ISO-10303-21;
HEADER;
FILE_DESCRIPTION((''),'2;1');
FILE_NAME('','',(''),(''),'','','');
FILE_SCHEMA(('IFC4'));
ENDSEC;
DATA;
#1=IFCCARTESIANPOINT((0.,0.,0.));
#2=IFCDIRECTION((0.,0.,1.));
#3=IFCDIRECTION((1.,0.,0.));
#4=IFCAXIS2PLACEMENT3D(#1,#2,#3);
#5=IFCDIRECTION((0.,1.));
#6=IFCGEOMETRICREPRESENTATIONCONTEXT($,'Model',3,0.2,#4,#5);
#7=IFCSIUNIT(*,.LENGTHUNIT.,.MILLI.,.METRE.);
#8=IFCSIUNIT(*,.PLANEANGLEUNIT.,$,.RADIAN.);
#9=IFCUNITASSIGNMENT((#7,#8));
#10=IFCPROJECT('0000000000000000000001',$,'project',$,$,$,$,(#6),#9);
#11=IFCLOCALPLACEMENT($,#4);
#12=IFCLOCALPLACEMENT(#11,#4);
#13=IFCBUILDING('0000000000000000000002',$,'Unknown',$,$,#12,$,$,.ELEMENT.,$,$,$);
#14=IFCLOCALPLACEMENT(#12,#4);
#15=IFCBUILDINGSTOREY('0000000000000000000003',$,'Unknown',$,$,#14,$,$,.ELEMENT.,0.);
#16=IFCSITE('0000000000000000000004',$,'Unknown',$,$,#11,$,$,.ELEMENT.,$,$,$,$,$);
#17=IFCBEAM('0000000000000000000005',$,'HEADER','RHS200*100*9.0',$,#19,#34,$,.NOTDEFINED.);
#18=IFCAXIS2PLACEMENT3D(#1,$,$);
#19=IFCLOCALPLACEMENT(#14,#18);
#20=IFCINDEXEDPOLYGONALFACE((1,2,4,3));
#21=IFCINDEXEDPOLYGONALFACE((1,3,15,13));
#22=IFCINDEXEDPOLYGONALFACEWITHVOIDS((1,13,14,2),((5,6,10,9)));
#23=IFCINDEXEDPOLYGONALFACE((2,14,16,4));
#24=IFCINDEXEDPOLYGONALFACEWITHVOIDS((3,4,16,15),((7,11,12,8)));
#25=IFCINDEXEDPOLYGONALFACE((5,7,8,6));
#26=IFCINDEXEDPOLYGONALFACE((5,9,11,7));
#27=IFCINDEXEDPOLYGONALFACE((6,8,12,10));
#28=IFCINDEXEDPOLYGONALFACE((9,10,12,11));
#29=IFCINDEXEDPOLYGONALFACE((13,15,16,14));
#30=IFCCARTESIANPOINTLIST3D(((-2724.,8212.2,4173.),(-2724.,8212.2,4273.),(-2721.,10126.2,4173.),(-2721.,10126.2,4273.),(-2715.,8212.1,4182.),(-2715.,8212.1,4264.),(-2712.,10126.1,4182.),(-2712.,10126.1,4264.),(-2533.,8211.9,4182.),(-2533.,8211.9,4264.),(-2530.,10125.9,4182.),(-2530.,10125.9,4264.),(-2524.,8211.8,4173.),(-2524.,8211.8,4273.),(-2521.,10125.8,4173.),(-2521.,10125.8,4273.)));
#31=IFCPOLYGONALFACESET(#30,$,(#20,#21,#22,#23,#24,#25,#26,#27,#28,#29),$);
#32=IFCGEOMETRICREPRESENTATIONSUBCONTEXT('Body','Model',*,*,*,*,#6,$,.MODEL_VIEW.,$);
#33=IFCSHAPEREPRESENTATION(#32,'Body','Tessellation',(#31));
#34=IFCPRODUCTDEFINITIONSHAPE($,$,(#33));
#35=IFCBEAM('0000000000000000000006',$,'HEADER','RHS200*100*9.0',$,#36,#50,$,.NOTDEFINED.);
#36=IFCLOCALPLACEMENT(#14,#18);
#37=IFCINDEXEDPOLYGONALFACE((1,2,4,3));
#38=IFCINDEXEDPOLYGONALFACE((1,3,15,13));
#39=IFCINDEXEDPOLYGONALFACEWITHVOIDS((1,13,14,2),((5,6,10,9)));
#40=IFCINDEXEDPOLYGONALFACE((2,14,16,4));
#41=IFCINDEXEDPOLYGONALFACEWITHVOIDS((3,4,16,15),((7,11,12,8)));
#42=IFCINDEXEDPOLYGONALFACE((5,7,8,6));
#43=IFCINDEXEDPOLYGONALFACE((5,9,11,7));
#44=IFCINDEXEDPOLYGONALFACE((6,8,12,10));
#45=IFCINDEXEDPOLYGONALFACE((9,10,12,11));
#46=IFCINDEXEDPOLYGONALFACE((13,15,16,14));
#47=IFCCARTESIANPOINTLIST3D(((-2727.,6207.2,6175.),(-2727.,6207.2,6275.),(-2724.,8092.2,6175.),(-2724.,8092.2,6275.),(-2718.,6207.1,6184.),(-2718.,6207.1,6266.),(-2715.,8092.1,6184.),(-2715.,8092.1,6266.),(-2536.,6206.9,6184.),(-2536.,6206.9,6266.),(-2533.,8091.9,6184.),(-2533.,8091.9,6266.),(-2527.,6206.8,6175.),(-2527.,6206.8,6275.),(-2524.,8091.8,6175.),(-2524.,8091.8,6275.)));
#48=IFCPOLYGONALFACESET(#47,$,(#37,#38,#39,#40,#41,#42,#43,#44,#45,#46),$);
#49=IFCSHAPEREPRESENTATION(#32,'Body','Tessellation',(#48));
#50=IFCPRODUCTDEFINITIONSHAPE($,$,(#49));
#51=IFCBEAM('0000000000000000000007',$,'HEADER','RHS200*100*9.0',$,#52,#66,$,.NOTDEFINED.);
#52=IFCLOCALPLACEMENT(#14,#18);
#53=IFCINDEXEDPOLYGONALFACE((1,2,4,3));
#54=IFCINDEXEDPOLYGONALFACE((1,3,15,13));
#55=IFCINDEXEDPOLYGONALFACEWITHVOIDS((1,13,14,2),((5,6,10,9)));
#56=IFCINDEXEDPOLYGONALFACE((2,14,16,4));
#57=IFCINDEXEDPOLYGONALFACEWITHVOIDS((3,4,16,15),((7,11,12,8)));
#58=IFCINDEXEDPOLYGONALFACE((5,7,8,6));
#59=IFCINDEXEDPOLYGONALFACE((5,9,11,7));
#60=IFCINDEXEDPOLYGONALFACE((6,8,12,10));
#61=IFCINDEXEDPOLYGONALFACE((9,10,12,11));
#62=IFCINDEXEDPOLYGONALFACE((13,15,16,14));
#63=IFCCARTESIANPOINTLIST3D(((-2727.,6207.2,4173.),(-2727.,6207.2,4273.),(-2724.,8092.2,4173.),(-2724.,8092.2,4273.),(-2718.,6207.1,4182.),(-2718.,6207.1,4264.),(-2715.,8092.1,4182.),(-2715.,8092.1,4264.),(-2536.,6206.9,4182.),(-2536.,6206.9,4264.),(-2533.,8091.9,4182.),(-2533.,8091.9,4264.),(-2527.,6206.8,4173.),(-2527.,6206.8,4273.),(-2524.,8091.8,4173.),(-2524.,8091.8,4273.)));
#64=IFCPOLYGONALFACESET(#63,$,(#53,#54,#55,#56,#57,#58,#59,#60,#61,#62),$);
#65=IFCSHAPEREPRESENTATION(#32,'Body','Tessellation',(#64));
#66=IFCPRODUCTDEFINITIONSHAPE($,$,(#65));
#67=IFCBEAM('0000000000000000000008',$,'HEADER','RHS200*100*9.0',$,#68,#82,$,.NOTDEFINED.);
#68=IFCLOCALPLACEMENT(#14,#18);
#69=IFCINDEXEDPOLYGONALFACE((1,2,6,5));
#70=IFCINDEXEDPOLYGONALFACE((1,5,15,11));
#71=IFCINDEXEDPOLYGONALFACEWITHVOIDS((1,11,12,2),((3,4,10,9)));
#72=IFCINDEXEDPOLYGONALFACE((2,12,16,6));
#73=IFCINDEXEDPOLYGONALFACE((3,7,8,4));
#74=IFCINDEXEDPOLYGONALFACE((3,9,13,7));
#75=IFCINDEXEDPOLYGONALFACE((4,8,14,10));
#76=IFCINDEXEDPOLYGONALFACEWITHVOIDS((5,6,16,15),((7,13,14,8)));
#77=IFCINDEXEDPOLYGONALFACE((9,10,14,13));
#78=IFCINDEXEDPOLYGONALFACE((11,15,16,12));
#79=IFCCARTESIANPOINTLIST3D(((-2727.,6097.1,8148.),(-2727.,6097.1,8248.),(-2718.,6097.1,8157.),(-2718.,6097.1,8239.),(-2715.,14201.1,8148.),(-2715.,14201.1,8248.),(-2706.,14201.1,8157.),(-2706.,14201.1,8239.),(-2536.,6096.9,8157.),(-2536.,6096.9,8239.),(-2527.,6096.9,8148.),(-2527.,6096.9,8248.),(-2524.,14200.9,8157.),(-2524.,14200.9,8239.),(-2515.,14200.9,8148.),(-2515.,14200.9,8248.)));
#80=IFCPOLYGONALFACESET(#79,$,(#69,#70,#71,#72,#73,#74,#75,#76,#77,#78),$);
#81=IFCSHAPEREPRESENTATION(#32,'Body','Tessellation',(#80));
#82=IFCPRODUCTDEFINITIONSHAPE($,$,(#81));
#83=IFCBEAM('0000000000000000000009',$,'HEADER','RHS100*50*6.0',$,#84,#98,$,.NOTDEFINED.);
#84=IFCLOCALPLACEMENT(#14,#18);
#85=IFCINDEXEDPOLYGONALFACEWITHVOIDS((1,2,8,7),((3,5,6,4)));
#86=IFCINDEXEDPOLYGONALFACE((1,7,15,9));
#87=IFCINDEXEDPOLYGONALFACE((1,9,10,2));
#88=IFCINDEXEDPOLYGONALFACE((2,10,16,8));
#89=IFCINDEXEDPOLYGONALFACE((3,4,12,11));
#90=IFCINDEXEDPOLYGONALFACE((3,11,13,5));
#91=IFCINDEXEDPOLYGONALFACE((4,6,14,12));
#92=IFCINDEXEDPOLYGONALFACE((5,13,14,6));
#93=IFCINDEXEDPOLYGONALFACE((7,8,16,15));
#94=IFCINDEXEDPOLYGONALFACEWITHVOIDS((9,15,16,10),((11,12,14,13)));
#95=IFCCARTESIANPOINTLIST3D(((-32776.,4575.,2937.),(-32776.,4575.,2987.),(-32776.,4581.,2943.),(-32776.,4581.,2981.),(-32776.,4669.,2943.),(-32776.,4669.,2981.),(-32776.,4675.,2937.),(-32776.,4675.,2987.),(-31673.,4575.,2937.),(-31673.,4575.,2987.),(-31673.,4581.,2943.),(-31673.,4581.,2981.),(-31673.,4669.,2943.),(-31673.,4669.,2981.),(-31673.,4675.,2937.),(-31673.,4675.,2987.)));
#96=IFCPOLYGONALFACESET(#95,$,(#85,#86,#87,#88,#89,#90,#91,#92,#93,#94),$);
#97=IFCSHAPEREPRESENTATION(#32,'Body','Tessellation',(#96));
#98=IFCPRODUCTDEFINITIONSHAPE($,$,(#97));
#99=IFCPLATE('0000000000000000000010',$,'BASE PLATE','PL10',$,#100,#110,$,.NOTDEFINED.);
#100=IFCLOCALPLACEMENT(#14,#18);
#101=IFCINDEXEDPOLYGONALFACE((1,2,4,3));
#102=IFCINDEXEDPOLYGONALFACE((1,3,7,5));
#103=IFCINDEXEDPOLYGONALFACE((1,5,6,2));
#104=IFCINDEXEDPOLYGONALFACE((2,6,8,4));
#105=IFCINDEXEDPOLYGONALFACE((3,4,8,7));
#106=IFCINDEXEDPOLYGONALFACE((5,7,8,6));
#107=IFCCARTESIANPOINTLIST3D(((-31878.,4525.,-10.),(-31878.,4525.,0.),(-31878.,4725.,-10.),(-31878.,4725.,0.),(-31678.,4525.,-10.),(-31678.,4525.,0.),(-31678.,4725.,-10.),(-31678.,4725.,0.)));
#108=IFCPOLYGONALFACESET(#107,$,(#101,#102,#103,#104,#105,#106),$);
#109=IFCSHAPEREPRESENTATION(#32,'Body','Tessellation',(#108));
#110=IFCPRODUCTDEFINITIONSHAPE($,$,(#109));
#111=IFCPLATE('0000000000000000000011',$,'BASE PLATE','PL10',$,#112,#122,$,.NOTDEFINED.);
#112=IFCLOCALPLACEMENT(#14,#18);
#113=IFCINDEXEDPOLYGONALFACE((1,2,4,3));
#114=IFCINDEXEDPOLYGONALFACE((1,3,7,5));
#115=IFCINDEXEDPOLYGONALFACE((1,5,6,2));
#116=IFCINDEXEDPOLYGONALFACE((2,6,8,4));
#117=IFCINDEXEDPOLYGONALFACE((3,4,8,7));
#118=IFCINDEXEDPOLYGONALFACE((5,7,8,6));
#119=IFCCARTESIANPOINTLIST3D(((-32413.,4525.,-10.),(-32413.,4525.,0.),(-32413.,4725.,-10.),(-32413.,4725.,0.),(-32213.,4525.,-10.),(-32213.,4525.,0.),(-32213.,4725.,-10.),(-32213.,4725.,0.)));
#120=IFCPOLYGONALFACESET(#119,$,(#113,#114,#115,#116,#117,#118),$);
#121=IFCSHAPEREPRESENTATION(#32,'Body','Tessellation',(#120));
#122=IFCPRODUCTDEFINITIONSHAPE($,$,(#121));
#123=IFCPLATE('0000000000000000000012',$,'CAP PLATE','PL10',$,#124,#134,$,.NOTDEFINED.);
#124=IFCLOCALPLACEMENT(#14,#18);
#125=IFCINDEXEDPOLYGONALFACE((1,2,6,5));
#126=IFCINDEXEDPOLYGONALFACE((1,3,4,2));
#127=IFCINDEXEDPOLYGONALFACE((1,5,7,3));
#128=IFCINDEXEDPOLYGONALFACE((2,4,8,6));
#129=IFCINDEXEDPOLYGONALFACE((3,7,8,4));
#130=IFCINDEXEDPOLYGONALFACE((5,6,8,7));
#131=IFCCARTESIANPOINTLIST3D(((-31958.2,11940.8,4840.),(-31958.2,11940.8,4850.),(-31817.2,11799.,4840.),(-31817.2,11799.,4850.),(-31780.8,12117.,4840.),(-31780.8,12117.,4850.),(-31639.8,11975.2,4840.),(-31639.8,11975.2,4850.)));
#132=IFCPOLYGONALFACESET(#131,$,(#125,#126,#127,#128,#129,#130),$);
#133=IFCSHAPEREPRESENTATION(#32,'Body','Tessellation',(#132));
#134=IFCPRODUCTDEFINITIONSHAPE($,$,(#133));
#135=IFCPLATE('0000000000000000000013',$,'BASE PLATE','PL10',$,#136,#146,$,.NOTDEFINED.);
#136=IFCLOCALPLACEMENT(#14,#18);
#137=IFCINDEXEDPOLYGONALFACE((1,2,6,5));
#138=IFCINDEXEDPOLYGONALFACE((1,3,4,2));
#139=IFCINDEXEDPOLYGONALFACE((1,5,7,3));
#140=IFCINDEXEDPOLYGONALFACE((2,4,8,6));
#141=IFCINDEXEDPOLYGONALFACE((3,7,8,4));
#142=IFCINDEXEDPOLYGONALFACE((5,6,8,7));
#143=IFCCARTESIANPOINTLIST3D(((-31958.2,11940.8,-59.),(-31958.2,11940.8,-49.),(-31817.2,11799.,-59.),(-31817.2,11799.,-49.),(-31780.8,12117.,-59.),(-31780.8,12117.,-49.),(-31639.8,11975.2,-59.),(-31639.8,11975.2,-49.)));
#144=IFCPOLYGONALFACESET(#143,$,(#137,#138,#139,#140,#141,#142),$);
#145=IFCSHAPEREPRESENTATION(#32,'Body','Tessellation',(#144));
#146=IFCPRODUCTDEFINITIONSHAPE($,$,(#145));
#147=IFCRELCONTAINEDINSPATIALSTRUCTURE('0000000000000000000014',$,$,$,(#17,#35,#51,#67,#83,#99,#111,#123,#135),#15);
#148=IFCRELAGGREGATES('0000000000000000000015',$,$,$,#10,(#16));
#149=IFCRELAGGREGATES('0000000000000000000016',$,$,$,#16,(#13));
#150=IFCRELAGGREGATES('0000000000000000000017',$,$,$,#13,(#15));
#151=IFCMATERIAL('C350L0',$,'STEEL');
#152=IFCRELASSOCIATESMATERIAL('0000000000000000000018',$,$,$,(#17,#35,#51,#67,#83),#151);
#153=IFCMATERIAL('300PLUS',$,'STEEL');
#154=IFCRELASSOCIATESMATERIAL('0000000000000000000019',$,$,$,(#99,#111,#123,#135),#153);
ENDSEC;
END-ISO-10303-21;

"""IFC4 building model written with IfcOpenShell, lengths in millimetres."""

from ifc_helpers import new_model, si_unit, direction, frame, origin_with_axes, place, context, subcontext, project, spatial, line, indexed_curve, outline, extrude, material, element, save


model = new_model("IFC4")

# Units and contexts
model_context = context("Model", 3, precision=0.2, world=origin_with_axes(), true_north=direction((0.0, 1.0)))
body_context = subcontext(model_context, "Body", "Model", "MODEL_VIEW")
ifc_project = project(units=[si_unit("LENGTHUNIT", "METRE", prefix="MILLI"), si_unit("PLANEANGLEUNIT", "RADIAN")], contexts=[model_context])

# Site, building, storey
site_placement = place(None, origin_with_axes())
site = spatial("IfcSite", under=ifc_project, at=site_placement, Name="Unknown", CompositionType="ELEMENT")
building_placement = place(site_placement, origin_with_axes())
building = spatial("IfcBuilding", under=site, at=building_placement, Name="Unknown", CompositionType="ELEMENT")
storey_placement = place(building_placement, origin_with_axes())
storey = spatial("IfcBuildingStorey", under=building, at=storey_placement, Name="Unknown", CompositionType="ELEMENT", Elevation=0.0)

# Shared definitions
ifc_material_1 = material(Name="C350L0", Category="STEEL")

# Beams
for number, where, z_axis, x_axis, name in (
    (1, (-2624.0, 8212.0, 4223.0), (0.0, 0.0, 1.0), (0.001567, 0.999999, 0.0), "HEADER"),
):
    element("IfcBeam", number, at=place(storey_placement, frame(where, z_axis=z_axis, x_axis=x_axis)), inside=storey, material=ifc_material_1, Name=name, Description="RHS200*100*9.0", PredefinedType="NOTDEFINED", context=body_context, shape_type="SolidModel", body=[
        extrude(outline(indexed_curve([(-50.0, -100.0), (50.0, -100.0), (50.0, 100.0), (-50.0, 100.0)], segments=[line(1, 2, 3, 4, 1)]), holes=[indexed_curve([(-41.0, -91.0), (-41.0, 91.0), (41.0, 91.0), (41.0, -91.0)], segments=[line(1, 2, 3, 4, 1)])]), frame((0.0, 0.0, 0.0), z_axis=(-1.0, 0.0, 0.0), x_axis=(0.0, 0.0, 1.0)), (0.0, 0.0, -1.0), 1914.0),
    ])
for number, where, z_axis, x_axis, name in (
    (2, (-2627.0, 6207.0, 6225.0), (0.0, 0.0, 1.0), (0.001592, 0.999999, 0.0), "HEADER"),
    (3, (-2627.0, 6207.0, 4223.0), (0.0, 0.0, 1.0), (0.001592, 0.999999, 0.0), "HEADER"),
):
    element("IfcBeam", number, at=place(storey_placement, frame(where, z_axis=z_axis, x_axis=x_axis)), inside=storey, material=ifc_material_1, Name=name, Description="RHS200*100*9.0", PredefinedType="NOTDEFINED", context=body_context, shape_type="SolidModel", body=[
        extrude(outline(indexed_curve([(-50.0, -100.0), (50.0, -100.0), (50.0, 100.0), (-50.0, 100.0)], segments=[line(1, 2, 3, 4, 1)]), holes=[indexed_curve([(-41.0, -91.0), (-41.0, 91.0), (41.0, 91.0), (41.0, -91.0)], segments=[line(1, 2, 3, 4, 1)])]), frame((0.0, 0.0, 0.0), z_axis=(-1.0, 0.0, 0.0), x_axis=(0.0, 0.0, 1.0)), (0.0, 0.0, -1.0), 1885.0),
    ])
beam_1_placement = place(storey_placement, frame((-2627.0, 6097.0, 8198.0), z_axis=(0.0, 0.0, 1.0), x_axis=(0.001481, 0.999999, 0.0)))
element("IfcBeam", 4, at=beam_1_placement, inside=storey, material=ifc_material_1, Name="HEADER", Description="RHS200*100*9.0", PredefinedType="NOTDEFINED", context=body_context, shape_type="SolidModel", body=[
    extrude(outline(indexed_curve([(-50.0, -100.0), (50.0, -100.0), (50.0, 100.0), (-50.0, 100.0)], segments=[line(1, 2, 3, 4, 1)]), holes=[indexed_curve([(-41.0, -91.0), (-41.0, 91.0), (41.0, 91.0), (41.0, -91.0)], segments=[line(1, 2, 3, 4, 1)])]), frame((0.0, 0.0, 0.0), z_axis=(-1.0, 0.0, 0.0), x_axis=(0.0, 0.0, 1.0)), (0.0, 0.0, -1.0), 8104.0),
])
beam_2_placement = place(storey_placement, frame((-32776.0, 4625.0, 2962.0), z_axis=(0.0, 0.0, 1.0), x_axis=(1.0, 0.0, 0.0)))
element("IfcBeam", 5, at=beam_2_placement, inside=storey, material=ifc_material_1, Name="HEADER", Description="RHS100*50*6.0", PredefinedType="NOTDEFINED", context=body_context, shape_type="SolidModel", body=[
    extrude(outline(indexed_curve([(-25.0, -50.0), (25.0, -50.0), (25.0, 50.0), (-25.0, 50.0)], segments=[line(1, 2, 3, 4, 1)]), holes=[indexed_curve([(-19.0, -44.0), (-19.0, 44.0), (19.0, 44.0), (19.0, -44.0)], segments=[line(1, 2, 3, 4, 1)])]), frame((0.0, 0.0, 0.0), z_axis=(-1.0, 0.0, 0.0), x_axis=(0.0, 0.0, 1.0)), (0.0, 0.0, -1.0), 1103.0),
])

# Plates
ifc_material_2 = material(Name="300PLUS", Category="STEEL")
for number, where, z_axis, x_axis, name in (
    (6, (-31878.0, 4525.0, -5.0), (0.0, 0.0, 1.0), (1.0, 0.0, 0.0), "BASE PLATE"),
    (7, (-32413.0, 4525.0, -5.0), (0.0, 0.0, 1.0), (1.0, 0.0, 0.0), "BASE PLATE"),
):
    element("IfcPlate", number, at=place(storey_placement, frame(where, z_axis=z_axis, x_axis=x_axis)), inside=storey, material=ifc_material_2, Name=name, Description="PL10", PredefinedType="NOTDEFINED", context=body_context, shape_type="SolidModel", body=[
        extrude(outline(indexed_curve([(0.0, 0.0), (200.0, 0.0), (200.0, 200.0), (0.0, 200.0)], segments=[line(1, 2, 3, 4, 1)])), frame((0.0, 0.0, 5.0), z_axis=(0.0, 0.0, 1.0), x_axis=(1.0, 0.0, 0.0)), (0.0, 0.0, -1.0), 10.0),
    ])
for number, where, z_axis, x_axis, name in (
    (8, (-31817.2, 11799.0, 4845.0), (0.0, 0.0, 1.0), (0.709502, 0.704703, 0.0), "CAP PLATE"),
    (9, (-31817.2, 11799.0, -54.0), (0.0, 0.0, 1.0), (0.709502, 0.704703, 0.0), "BASE PLATE"),
):
    element("IfcPlate", number, at=place(storey_placement, frame(where, z_axis=z_axis, x_axis=x_axis)), inside=storey, material=ifc_material_2, Name=name, Description="PL10", PredefinedType="NOTDEFINED", context=body_context, shape_type="SolidModel", body=[
        extrude(outline(indexed_curve([(0.0, 0.0), (250.0, 0.0), (249.9, 200.0), (-0.1, 200.0)], segments=[line(1, 2, 3, 4, 1)])), frame((0.0, 0.0, 5.0), z_axis=(0.0, 0.0, 1.0), x_axis=(1.0, 0.0, 0.0)), (0.0, 0.0, -1.0), 10.0),
    ])

save(model, "model.ifc")
